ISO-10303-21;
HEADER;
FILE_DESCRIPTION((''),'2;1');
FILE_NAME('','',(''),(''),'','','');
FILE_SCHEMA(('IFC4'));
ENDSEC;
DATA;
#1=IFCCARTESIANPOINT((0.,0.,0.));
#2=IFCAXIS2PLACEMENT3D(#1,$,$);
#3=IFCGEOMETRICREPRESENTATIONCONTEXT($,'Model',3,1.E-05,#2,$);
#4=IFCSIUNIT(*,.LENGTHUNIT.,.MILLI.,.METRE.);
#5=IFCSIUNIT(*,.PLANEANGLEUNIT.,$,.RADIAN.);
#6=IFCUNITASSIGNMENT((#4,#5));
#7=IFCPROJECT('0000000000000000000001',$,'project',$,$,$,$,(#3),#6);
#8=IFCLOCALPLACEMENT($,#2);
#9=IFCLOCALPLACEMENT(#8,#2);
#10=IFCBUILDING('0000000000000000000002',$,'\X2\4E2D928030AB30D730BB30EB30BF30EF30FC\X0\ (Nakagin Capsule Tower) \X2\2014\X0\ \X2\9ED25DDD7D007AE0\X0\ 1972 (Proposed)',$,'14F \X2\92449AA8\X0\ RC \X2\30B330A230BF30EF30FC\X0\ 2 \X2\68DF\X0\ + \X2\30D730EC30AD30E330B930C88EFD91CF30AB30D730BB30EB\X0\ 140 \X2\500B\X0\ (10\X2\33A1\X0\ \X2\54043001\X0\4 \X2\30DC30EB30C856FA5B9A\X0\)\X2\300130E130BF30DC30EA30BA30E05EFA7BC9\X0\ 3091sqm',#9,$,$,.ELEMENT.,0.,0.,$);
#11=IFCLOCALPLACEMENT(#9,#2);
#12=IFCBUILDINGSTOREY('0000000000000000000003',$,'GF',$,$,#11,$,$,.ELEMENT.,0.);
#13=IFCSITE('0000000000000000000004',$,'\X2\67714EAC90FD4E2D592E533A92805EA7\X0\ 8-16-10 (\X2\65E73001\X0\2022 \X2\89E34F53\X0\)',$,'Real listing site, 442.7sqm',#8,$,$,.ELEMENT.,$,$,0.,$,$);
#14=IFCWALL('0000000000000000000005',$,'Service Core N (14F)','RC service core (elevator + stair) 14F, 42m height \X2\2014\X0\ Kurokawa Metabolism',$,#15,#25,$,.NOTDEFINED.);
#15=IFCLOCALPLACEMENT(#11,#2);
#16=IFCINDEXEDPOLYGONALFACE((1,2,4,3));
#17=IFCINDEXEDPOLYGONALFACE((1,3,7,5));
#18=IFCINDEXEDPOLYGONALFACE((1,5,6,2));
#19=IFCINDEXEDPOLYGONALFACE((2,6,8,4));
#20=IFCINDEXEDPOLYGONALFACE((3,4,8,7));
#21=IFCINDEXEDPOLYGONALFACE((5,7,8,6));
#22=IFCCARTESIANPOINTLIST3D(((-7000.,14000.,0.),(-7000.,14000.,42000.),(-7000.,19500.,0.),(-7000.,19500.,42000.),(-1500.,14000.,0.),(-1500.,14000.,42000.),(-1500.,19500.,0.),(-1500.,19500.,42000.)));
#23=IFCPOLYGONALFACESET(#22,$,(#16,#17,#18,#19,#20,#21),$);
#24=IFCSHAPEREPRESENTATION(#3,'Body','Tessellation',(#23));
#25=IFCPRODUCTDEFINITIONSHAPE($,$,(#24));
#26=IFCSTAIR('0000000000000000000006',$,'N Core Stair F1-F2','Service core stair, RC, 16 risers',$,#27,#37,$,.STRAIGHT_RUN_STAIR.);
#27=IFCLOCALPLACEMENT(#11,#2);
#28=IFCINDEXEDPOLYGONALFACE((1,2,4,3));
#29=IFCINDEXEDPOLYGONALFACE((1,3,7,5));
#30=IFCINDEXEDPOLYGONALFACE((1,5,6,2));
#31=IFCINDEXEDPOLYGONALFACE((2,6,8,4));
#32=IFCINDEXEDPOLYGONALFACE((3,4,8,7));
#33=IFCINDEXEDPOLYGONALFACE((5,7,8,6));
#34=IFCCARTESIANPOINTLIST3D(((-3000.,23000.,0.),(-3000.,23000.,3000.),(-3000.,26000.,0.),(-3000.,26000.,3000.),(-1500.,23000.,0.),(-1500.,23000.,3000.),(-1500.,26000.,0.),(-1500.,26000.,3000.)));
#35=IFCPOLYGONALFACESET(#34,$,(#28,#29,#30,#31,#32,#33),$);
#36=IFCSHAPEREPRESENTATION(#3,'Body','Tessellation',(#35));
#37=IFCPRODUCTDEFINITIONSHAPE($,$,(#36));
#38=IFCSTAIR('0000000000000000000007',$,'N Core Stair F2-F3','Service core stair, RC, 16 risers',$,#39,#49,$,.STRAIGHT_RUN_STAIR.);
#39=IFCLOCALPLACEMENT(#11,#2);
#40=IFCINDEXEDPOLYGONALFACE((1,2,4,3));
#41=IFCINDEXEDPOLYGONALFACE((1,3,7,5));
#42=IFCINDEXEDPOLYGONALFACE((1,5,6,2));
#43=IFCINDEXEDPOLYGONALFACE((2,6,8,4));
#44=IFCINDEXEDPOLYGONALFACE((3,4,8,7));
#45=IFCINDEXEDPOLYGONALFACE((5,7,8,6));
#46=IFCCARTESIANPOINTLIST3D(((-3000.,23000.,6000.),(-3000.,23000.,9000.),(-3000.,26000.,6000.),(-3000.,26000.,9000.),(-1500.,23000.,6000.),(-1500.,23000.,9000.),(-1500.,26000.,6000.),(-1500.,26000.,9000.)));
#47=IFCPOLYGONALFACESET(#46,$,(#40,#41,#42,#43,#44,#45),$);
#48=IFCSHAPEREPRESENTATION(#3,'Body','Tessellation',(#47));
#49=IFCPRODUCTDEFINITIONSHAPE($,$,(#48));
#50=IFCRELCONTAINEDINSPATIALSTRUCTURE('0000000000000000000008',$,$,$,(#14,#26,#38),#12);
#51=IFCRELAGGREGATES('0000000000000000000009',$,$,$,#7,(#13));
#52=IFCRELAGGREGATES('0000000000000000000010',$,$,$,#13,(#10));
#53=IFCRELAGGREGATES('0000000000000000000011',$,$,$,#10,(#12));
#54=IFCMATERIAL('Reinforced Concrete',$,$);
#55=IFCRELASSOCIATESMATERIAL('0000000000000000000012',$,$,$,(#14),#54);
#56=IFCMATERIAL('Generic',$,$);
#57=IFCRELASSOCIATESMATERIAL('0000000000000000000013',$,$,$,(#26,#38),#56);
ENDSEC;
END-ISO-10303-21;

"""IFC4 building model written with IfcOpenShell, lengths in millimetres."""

from ifc_helpers import new_model, si_unit, frame, frame_2d, origin, place, context, project, spatial, rectangle, extrude, material, element, save


model = new_model("IFC4")

# Units and contexts
model_context = context("Model", 3, precision=1e-05, world=origin())
ifc_project = project(units=[si_unit("LENGTHUNIT", "METRE", prefix="MILLI"), si_unit("PLANEANGLEUNIT", "RADIAN")], contexts=[model_context])

# Site, building, storey
site_placement = place(None, origin())
site = spatial("IfcSite", under=ifc_project, at=site_placement, Name="東京都中央区銀座 8-16-10 (旧、2022 解体)", ObjectType="Real listing site, 442.7sqm", CompositionType="ELEMENT", RefElevation=0.0)
building_placement = place(site_placement, origin())
building = spatial("IfcBuilding", under=site, at=building_placement, Name="中銀カプセルタワー (Nakagin Capsule Tower) — 黒川紀章 1972 (Proposed)", ObjectType="14F 鉄骨 RC コアタワー 2 棟 + プレキャスト軽量カプセル 140 個 (10㎡ 各、4 ボルト固定)、メタボリズム建築 3091sqm", CompositionType="ELEMENT", ElevationOfRefHeight=0.0, ElevationOfTerrain=0.0)
storey_placement = place(building_placement, origin())
storey = spatial("IfcBuildingStorey", under=building, at=storey_placement, Name="GF", CompositionType="ELEMENT", Elevation=0.0)

# Wall
ifc_material_1 = material(Name="Reinforced Concrete")
wall_placement = place(storey_placement, frame((-3500.0, 7000.0, 0.0)))
element("IfcWall", 1, at=wall_placement, inside=storey, material=ifc_material_1, Name="Service Core N (14F)", Description="RC service core (elevator + stair) 14F, 42m height — Kurokawa Metabolism", PredefinedType="NOTDEFINED", context=model_context, shape_type="SweptSolid", body=[
    extrude(rectangle(XDim=5500.0, YDim=5500.0, at=frame_2d((2750.0, 2750.0))), frame((-3500.0, 7000.0, 0.0)), (0.0, 0.0, 1.0), 42000.0),
])

# Stairs
ifc_material_2 = material(Name="Generic")
stair_1_placement = place(storey_placement, frame((-1500.0, 11500.0, 0.0)))
element("IfcStair", 2, at=stair_1_placement, inside=storey, material=ifc_material_2, Name="N Core Stair F1-F2", Description="Service core stair, RC, 16 risers", PredefinedType="STRAIGHT_RUN_STAIR", context=model_context, shape_type="SweptSolid", body=[
    extrude(rectangle(XDim=1500.0, YDim=3000.0, at=frame_2d((750.0, 1500.0))), frame((-1500.0, 11500.0, 0.0)), (0.0, 0.0, 1.0), 3000.0),
])
stair_2_placement = place(storey_placement, frame((-1500.0, 11500.0, 3000.0)))
element("IfcStair", 3, at=stair_2_placement, inside=storey, material=ifc_material_2, Name="N Core Stair F2-F3", Description="Service core stair, RC, 16 risers", PredefinedType="STRAIGHT_RUN_STAIR", context=model_context, shape_type="SweptSolid", body=[
    extrude(rectangle(XDim=1500.0, YDim=3000.0, at=frame_2d((750.0, 1500.0))), frame((-1500.0, 11500.0, 3000.0)), (0.0, 0.0, 1.0), 3000.0),
])

save(model, "model.ifc")
